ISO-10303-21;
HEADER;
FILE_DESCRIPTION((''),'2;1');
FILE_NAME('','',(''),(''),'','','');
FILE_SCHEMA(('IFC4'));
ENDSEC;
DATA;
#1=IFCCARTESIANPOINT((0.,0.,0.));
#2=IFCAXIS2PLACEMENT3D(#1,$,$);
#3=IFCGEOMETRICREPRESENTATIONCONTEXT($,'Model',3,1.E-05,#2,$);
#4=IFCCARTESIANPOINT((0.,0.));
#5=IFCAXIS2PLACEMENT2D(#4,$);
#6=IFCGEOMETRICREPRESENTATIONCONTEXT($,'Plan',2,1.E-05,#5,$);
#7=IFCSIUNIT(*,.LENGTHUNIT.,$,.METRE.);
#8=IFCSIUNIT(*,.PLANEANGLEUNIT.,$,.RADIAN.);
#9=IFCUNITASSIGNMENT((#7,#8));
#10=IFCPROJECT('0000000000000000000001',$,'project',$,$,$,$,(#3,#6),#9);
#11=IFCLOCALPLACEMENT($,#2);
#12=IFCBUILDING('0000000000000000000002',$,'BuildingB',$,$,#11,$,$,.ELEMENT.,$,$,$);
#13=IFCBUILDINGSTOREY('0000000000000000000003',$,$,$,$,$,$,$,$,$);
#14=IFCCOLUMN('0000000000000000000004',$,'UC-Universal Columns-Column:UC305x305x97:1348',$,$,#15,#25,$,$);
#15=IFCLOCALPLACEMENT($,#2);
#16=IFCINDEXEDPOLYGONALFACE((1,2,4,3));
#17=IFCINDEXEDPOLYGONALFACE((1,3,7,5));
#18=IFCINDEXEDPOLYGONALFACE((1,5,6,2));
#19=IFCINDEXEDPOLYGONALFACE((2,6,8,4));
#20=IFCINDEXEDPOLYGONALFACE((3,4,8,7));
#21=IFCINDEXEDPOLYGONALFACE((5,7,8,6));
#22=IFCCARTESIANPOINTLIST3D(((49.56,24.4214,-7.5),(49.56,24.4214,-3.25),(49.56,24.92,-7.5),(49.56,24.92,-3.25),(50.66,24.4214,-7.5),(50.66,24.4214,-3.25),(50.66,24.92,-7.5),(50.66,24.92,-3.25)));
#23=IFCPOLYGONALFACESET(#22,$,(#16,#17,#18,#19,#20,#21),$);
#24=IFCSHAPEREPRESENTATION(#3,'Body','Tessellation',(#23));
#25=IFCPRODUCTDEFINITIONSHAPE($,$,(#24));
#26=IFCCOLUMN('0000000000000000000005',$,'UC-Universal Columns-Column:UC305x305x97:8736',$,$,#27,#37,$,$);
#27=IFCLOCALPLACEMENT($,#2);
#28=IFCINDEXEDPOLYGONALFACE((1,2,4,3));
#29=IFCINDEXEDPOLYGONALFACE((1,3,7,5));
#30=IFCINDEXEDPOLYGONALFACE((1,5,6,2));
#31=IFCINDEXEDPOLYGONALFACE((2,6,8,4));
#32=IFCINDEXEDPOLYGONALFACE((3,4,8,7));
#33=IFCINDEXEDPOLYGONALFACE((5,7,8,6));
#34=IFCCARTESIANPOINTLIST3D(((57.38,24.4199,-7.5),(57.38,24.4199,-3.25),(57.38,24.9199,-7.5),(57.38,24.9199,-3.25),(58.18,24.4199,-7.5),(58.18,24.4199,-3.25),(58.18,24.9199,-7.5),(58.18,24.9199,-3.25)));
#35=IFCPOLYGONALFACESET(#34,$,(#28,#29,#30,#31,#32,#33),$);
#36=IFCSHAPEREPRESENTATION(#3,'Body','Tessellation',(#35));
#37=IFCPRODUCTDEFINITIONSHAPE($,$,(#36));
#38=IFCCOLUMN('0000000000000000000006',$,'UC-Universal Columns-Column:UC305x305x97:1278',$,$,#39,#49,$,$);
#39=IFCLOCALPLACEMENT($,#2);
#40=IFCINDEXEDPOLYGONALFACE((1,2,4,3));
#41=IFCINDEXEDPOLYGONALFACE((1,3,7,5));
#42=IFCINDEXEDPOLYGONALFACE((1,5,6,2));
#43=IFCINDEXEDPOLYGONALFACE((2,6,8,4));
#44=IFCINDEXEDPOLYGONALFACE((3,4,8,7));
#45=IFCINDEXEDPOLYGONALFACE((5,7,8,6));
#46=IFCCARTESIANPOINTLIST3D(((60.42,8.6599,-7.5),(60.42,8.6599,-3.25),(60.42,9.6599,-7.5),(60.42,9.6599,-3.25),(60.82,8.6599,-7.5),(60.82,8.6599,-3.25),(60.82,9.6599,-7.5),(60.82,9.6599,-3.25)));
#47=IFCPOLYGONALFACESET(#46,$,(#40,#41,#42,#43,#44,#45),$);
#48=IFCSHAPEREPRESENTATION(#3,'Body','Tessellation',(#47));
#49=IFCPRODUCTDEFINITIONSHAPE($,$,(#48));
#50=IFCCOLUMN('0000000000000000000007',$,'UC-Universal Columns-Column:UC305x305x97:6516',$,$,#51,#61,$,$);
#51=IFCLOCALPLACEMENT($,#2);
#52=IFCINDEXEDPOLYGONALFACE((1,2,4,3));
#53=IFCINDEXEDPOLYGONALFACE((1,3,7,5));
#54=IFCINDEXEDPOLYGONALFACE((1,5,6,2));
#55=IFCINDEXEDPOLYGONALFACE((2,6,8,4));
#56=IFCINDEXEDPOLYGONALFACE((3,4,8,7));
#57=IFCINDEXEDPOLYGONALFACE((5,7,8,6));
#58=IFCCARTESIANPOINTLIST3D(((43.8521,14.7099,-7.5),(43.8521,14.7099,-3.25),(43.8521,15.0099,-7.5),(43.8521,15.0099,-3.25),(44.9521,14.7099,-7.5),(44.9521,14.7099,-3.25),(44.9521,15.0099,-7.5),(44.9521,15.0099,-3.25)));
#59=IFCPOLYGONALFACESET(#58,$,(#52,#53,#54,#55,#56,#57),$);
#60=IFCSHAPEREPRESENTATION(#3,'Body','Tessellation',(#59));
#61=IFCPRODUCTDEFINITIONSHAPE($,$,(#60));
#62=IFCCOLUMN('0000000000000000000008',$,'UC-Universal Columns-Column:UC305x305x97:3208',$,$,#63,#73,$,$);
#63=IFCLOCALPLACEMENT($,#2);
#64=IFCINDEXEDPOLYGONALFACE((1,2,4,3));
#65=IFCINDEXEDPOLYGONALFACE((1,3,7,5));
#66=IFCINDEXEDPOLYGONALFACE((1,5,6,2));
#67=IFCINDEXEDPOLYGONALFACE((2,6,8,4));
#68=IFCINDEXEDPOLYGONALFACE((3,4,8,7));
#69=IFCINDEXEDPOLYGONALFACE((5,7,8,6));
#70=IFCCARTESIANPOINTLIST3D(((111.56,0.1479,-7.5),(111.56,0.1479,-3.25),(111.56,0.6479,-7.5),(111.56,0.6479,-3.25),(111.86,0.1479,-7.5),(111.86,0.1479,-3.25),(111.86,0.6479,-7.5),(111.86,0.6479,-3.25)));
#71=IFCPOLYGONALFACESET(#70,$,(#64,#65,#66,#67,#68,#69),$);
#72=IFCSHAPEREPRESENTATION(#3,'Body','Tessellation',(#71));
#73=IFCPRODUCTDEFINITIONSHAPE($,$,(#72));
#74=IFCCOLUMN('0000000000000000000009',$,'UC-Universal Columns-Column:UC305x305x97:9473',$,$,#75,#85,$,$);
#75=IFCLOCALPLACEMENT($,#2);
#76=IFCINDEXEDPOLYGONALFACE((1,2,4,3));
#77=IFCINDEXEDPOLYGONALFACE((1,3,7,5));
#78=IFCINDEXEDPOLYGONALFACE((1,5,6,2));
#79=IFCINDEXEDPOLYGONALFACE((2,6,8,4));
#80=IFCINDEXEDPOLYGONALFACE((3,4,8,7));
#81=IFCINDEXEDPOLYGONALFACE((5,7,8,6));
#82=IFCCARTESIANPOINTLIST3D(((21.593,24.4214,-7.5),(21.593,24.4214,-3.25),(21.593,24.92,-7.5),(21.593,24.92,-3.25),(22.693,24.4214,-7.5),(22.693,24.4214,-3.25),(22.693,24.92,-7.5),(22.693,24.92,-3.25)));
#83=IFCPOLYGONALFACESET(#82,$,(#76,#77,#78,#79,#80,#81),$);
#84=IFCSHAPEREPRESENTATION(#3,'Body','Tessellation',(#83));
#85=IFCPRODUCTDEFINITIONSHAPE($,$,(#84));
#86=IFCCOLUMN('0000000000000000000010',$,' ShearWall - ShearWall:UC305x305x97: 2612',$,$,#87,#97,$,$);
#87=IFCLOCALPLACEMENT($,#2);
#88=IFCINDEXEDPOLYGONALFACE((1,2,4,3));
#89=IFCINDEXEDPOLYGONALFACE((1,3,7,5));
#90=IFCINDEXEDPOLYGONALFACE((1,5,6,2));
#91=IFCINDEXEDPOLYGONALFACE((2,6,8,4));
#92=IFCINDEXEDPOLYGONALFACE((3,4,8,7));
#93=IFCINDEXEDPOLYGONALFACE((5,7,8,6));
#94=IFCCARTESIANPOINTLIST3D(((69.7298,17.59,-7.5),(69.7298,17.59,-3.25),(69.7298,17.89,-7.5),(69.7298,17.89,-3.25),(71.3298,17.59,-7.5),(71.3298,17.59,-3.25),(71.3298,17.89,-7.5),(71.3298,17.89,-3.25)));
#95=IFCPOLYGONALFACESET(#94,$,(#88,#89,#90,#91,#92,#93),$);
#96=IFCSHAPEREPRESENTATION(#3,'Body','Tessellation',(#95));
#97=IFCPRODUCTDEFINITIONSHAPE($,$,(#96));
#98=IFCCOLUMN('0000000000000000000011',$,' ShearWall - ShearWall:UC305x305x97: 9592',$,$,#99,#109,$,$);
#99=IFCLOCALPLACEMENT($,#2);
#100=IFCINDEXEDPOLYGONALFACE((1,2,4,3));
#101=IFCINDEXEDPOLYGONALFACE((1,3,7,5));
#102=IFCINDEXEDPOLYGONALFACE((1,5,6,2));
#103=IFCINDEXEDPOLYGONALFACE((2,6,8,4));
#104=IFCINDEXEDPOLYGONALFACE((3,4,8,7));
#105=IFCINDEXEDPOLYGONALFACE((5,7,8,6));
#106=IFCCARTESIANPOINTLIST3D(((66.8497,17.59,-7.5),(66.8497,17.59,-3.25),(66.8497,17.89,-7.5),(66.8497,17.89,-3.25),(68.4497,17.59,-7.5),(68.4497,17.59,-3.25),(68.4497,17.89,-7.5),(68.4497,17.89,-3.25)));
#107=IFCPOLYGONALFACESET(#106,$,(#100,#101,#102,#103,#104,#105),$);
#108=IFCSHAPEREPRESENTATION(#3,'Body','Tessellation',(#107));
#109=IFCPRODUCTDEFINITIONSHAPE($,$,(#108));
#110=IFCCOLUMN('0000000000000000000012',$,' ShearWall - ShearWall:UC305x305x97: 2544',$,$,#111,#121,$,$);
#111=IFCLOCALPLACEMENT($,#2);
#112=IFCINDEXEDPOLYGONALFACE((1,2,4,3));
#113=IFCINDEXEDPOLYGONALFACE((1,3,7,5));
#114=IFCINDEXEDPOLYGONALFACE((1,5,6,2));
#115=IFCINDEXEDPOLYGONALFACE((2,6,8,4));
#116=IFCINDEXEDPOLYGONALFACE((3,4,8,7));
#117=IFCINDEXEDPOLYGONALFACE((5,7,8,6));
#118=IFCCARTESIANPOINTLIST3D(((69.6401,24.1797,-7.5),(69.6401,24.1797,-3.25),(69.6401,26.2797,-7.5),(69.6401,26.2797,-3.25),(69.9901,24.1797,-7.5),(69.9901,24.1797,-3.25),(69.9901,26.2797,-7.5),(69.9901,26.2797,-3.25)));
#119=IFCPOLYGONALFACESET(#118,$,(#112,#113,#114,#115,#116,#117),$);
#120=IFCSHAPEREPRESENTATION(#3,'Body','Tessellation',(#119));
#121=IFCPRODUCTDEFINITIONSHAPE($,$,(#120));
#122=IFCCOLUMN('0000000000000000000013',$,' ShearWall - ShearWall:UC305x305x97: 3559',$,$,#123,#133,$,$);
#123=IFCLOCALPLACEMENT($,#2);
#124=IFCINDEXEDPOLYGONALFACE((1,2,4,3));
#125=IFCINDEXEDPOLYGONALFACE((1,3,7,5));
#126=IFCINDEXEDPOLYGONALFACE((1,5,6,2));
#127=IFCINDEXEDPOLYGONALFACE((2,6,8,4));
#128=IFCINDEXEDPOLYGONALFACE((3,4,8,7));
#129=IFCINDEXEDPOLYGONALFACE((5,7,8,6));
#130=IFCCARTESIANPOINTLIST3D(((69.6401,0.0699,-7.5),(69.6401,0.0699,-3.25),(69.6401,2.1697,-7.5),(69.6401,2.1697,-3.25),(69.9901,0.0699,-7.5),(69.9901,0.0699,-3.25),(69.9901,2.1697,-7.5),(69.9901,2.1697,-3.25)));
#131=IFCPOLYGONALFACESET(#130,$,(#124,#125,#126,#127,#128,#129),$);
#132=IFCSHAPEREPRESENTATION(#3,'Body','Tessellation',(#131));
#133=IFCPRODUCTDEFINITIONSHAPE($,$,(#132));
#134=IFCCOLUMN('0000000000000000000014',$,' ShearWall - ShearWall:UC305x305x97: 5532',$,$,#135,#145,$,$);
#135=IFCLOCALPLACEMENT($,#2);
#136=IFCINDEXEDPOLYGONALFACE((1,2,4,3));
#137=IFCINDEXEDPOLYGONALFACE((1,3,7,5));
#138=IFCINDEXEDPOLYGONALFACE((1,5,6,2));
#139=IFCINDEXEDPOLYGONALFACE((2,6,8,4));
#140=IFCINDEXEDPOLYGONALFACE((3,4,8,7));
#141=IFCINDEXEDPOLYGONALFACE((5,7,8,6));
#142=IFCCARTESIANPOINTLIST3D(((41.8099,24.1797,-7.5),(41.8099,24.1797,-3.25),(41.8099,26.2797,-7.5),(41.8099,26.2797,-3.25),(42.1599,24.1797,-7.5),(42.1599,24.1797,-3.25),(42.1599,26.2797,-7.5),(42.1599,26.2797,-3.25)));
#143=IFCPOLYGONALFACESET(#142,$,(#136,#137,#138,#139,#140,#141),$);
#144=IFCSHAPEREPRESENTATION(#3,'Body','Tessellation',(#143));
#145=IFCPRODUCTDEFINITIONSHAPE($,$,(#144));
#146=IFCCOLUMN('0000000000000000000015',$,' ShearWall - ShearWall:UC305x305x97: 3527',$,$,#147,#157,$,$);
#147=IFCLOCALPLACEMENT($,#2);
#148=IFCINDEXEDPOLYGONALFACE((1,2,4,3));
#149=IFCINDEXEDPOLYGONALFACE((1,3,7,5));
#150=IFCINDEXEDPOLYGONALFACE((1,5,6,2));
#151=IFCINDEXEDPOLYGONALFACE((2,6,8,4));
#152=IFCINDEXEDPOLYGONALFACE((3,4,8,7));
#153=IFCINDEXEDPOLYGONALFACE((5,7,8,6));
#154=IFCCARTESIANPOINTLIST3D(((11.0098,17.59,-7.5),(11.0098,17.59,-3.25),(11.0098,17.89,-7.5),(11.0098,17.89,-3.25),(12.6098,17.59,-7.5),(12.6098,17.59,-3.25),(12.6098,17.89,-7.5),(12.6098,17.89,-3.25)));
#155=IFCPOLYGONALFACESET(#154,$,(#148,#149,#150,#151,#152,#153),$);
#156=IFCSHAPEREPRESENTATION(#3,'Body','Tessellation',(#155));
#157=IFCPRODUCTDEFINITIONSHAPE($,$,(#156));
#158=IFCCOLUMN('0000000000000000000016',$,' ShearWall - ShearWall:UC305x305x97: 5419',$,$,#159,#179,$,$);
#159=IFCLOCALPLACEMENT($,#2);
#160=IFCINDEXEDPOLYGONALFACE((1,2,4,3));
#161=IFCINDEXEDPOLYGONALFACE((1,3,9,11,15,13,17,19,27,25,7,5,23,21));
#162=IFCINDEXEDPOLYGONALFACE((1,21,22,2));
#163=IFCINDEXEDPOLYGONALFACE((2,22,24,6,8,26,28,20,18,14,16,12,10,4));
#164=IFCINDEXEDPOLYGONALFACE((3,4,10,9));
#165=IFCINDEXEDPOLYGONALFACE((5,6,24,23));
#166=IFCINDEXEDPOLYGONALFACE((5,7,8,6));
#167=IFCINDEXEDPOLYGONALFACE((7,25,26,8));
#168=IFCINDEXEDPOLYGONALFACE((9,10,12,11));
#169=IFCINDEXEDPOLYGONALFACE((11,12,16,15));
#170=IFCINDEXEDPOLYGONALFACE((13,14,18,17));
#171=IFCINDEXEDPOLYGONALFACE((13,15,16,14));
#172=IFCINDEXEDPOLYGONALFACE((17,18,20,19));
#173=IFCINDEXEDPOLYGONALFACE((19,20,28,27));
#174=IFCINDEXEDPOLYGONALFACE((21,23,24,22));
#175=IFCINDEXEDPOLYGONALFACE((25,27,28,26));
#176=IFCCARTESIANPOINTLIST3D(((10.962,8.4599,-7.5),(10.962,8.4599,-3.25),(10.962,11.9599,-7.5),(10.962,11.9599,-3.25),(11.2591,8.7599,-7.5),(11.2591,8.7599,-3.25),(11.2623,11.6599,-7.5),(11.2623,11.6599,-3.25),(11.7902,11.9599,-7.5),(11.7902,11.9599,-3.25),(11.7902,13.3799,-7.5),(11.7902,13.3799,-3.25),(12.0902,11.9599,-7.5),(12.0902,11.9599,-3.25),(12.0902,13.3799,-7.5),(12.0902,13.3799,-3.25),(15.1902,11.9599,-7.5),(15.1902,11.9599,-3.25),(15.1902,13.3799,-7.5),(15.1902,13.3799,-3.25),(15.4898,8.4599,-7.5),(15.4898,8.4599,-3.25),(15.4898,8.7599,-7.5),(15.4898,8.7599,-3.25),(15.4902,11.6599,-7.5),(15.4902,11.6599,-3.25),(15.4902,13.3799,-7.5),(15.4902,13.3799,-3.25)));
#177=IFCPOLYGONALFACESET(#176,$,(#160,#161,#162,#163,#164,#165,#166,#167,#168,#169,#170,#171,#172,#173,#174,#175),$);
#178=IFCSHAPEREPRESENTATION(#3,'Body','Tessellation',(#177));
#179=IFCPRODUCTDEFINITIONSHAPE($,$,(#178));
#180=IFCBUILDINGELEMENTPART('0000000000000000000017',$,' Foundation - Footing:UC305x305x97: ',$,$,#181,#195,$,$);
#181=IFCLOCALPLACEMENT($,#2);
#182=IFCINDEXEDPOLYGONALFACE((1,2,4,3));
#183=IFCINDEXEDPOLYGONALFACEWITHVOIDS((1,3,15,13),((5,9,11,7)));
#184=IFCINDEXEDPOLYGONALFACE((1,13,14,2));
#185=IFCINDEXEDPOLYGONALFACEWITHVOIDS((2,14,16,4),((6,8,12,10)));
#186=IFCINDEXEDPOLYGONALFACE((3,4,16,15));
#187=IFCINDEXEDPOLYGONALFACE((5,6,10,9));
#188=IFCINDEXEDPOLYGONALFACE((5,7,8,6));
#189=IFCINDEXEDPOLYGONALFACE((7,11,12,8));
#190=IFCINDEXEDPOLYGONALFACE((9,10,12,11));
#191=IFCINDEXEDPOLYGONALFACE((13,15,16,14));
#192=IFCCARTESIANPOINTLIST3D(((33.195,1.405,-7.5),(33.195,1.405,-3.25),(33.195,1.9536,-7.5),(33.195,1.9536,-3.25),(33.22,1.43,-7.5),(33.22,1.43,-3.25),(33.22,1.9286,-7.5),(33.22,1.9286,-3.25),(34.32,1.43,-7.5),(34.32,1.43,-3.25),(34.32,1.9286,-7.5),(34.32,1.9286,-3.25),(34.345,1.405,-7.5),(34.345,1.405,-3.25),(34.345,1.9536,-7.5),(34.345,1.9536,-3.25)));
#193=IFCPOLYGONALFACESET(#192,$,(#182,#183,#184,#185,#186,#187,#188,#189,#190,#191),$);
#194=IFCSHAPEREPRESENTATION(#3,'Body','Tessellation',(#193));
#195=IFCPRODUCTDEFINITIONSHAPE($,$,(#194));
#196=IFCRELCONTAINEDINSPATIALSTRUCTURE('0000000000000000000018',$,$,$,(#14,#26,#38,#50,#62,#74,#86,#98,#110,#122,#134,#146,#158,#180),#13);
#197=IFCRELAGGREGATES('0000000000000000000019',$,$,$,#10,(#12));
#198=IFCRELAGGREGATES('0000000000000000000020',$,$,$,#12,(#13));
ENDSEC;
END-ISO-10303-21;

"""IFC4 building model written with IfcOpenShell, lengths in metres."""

from ifc_helpers import new_model, si_unit, origin, origin_with_axes, origin_2d, place, context, project, spatial, polyline, outline, extrude, element, save


model = new_model("IFC4")

# Units and contexts
model_context = context("Model", 3, precision=1e-05, world=origin())
plan_context = context("Plan", 2, precision=1e-05, world=origin_2d())
ifc_project = project(units=[si_unit("LENGTHUNIT", "METRE"), si_unit("PLANEANGLEUNIT", "RADIAN")], contexts=[model_context, plan_context])

# Building, storey
building_placement = place(None, origin())
building = spatial("IfcBuilding", under=ifc_project, at=building_placement, Name="BuildingB", CompositionType="ELEMENT")
storey = spatial("IfcBuildingStorey", under=building)

# Columns
element("IfcColumn", 1, inside=storey, Name="UC-Universal Columns-Column:UC305x305x97:1348", context=model_context, shape_type="SweptSolid", body=[
    extrude(outline(polyline([(50.66, 24.4214, -7.5), (49.56, 24.4214, -7.5), (49.56, 24.92, -7.5), (50.66, 24.92, -7.5), (50.66, 24.4214, -7.5)])), None, (0.0, 0.0, 1.0), 4.25),
])
element("IfcColumn", 2, inside=storey, Name="UC-Universal Columns-Column:UC305x305x97:8736", context=model_context, shape_type="SweptSolid", body=[
    extrude(outline(polyline([(57.38, 24.4199, -7.5), (58.18, 24.4199, -7.5), (58.18, 24.9199, -7.5), (57.38, 24.9199, -7.5), (57.38, 24.4199, -7.5)])), None, (0.0, 0.0, 1.0), 4.25),
])
element("IfcColumn", 3, inside=storey, Name="UC-Universal Columns-Column:UC305x305x97:1278", context=model_context, shape_type="SweptSolid", body=[
    extrude(outline(polyline([(60.42, 8.6599, -7.5), (60.82, 8.6599, -7.5), (60.82, 9.6599, -7.5), (60.42, 9.6599, -7.5), (60.42, 8.6599, -7.5)])), None, (0.0, 0.0, 1.0), 4.25),
])
element("IfcColumn", 4, inside=storey, Name="UC-Universal Columns-Column:UC305x305x97:6516", context=model_context, shape_type="SweptSolid", body=[
    extrude(outline(polyline([(44.9521, 14.7099, -7.5), (44.9521, 15.0099, -7.5), (43.8521, 15.0099, -7.5), (43.8521, 14.7099, -7.5), (44.9521, 14.7099, -7.5)])), None, (0.0, 0.0, 1.0), 4.25),
])
element("IfcColumn", 5, inside=storey, Name="UC-Universal Columns-Column:UC305x305x97:3208", context=model_context, shape_type="SweptSolid", body=[
    extrude(outline(polyline([(111.56, 0.6479, -7.5), (111.86, 0.6479, -7.5), (111.86, 0.1479, -7.5), (111.56, 0.1479, -7.5), (111.56, 0.6479, -7.5)])), None, (0.0, 0.0, 1.0), 4.25),
])
element("IfcColumn", 6, inside=storey, Name="UC-Universal Columns-Column:UC305x305x97:9473", context=model_context, shape_type="SweptSolid", body=[
    extrude(outline(polyline([(21.593, 24.4214, -7.5), (22.693, 24.4214, -7.5), (22.693, 24.92, -7.5), (21.593, 24.92, -7.5), (21.593, 24.4214, -7.5)])), None, (0.0, 0.0, 1.0), 4.25),
])
column_1_placement = place(None, origin_with_axes())
element("IfcColumn", 7, at=column_1_placement, inside=storey, Name=" ShearWall - ShearWall:UC305x305x97: 2612", context=model_context, shape_type="SweptSolid", body=[
    extrude(outline(polyline([(69.7298, 17.59, -7.5), (69.7298, 17.89, -7.5), (71.3298, 17.89, -7.5), (71.3298, 17.59, -7.5), (69.7298, 17.59, -7.5)])), None, (0.0, 0.0, 1.0), 4.25),
])
column_2_placement = place(None, origin_with_axes())
element("IfcColumn", 8, at=column_2_placement, inside=storey, Name=" ShearWall - ShearWall:UC305x305x97: 9592", context=model_context, shape_type="SweptSolid", body=[
    extrude(outline(polyline([(66.8497, 17.59, -7.5), (66.8497, 17.89, -7.5), (68.4497, 17.89, -7.5), (68.4497, 17.59, -7.5), (66.8497, 17.59, -7.5)])), None, (0.0, 0.0, 1.0), 4.25),
])
column_3_placement = place(None, origin_with_axes())
element("IfcColumn", 9, at=column_3_placement, inside=storey, Name=" ShearWall - ShearWall:UC305x305x97: 2544", context=model_context, shape_type="SweptSolid", body=[
    extrude(outline(polyline([(69.9901, 26.2797, -7.5), (69.6401, 26.2797, -7.5), (69.6401, 24.1797, -7.5), (69.9901, 24.1797, -7.5), (69.9901, 26.2797, -7.5)])), None, (0.0, 0.0, 1.0), 4.25),
])
column_4_placement = place(None, origin_with_axes())
element("IfcColumn", 10, at=column_4_placement, inside=storey, Name=" ShearWall - ShearWall:UC305x305x97: 3559", context=model_context, shape_type="SweptSolid", body=[
    extrude(outline(polyline([(69.9901, 2.1697, -7.5), (69.6401, 2.1697, -7.5), (69.6401, 0.0699, -7.5), (69.9901, 0.0699, -7.5), (69.9901, 2.1697, -7.5)])), None, (0.0, 0.0, 1.0), 4.25),
])
column_5_placement = place(None, origin_with_axes())
element("IfcColumn", 11, at=column_5_placement, inside=storey, Name=" ShearWall - ShearWall:UC305x305x97: 5532", context=model_context, shape_type="SweptSolid", body=[
    extrude(outline(polyline([(41.8099, 26.2797, -7.5), (42.1599, 26.2797, -7.5), (42.1599, 24.1797, -7.5), (41.8099, 24.1797, -7.5), (41.8099, 26.2797, -7.5)])), None, (0.0, 0.0, 1.0), 4.25),
])
column_6_placement = place(None, origin_with_axes())
element("IfcColumn", 12, at=column_6_placement, inside=storey, Name=" ShearWall - ShearWall:UC305x305x97: 3527", context=model_context, shape_type="SweptSolid", body=[
    extrude(outline(polyline([(11.0098, 17.59, -7.5), (11.0098, 17.89, -7.5), (12.6098, 17.89, -7.5), (12.6098, 17.59, -7.5), (11.0098, 17.59, -7.5)])), None, (0.0, 0.0, 1.0), 4.25),
])
column_7_placement = place(None, origin_with_axes())
element("IfcColumn", 13, at=column_7_placement, inside=storey, Name=" ShearWall - ShearWall:UC305x305x97: 5419", context=model_context, shape_type="SweptSolid", body=[
    extrude(outline(polyline([(10.962, 8.4599, -7.5), (15.4898, 8.4599, -7.5), (15.4898, 8.7599, -7.5), (11.2591, 8.7599, -7.5), (11.2623, 11.6599, -7.5), (15.4902, 11.6599, -7.5), (15.4902, 13.3799, -7.5), (15.1902, 13.3799, -7.5), (15.1902, 11.9599, -7.5), (12.0902, 11.9599, -7.5), (12.0902, 13.3799, -7.5), (11.7902, 13.3799, -7.5), (11.7902, 11.9599, -7.5), (10.962, 11.9599, -7.5), (10.962, 8.4599, -7.5)])), None, (0.0, 0.0, 1.0), 4.25),
])

# Building element part, opening
building_element_part_1 = element("IfcBuildingElementPart", 14, inside=storey, Name=" Foundation - Footing:UC305x305x97: ", context=model_context, shape_type="SweptSolid", body=[
    extrude(outline(polyline([(34.345, 1.405, -7.5), (33.195, 1.405, -7.5), (33.195, 1.9536, -7.5), (34.345, 1.9536, -7.5), (34.345, 1.405, -7.5)])), None, (0.0, 0.0, 1.0), 4.25),
])
element("IfcOpeningElement", 15, inside=storey, cuts=building_element_part_1, context=model_context, shape_type="SweptSolid", body=[
    extrude(outline(polyline([(34.32, 1.43, -7.5), (33.22, 1.43, -7.5), (33.22, 1.9286, -7.5), (34.32, 1.9286, -7.5), (34.32, 1.43, -7.5)])), None, (0.0, 0.0, 1.0), 4.25),
])

save(model, "model.ifc")
